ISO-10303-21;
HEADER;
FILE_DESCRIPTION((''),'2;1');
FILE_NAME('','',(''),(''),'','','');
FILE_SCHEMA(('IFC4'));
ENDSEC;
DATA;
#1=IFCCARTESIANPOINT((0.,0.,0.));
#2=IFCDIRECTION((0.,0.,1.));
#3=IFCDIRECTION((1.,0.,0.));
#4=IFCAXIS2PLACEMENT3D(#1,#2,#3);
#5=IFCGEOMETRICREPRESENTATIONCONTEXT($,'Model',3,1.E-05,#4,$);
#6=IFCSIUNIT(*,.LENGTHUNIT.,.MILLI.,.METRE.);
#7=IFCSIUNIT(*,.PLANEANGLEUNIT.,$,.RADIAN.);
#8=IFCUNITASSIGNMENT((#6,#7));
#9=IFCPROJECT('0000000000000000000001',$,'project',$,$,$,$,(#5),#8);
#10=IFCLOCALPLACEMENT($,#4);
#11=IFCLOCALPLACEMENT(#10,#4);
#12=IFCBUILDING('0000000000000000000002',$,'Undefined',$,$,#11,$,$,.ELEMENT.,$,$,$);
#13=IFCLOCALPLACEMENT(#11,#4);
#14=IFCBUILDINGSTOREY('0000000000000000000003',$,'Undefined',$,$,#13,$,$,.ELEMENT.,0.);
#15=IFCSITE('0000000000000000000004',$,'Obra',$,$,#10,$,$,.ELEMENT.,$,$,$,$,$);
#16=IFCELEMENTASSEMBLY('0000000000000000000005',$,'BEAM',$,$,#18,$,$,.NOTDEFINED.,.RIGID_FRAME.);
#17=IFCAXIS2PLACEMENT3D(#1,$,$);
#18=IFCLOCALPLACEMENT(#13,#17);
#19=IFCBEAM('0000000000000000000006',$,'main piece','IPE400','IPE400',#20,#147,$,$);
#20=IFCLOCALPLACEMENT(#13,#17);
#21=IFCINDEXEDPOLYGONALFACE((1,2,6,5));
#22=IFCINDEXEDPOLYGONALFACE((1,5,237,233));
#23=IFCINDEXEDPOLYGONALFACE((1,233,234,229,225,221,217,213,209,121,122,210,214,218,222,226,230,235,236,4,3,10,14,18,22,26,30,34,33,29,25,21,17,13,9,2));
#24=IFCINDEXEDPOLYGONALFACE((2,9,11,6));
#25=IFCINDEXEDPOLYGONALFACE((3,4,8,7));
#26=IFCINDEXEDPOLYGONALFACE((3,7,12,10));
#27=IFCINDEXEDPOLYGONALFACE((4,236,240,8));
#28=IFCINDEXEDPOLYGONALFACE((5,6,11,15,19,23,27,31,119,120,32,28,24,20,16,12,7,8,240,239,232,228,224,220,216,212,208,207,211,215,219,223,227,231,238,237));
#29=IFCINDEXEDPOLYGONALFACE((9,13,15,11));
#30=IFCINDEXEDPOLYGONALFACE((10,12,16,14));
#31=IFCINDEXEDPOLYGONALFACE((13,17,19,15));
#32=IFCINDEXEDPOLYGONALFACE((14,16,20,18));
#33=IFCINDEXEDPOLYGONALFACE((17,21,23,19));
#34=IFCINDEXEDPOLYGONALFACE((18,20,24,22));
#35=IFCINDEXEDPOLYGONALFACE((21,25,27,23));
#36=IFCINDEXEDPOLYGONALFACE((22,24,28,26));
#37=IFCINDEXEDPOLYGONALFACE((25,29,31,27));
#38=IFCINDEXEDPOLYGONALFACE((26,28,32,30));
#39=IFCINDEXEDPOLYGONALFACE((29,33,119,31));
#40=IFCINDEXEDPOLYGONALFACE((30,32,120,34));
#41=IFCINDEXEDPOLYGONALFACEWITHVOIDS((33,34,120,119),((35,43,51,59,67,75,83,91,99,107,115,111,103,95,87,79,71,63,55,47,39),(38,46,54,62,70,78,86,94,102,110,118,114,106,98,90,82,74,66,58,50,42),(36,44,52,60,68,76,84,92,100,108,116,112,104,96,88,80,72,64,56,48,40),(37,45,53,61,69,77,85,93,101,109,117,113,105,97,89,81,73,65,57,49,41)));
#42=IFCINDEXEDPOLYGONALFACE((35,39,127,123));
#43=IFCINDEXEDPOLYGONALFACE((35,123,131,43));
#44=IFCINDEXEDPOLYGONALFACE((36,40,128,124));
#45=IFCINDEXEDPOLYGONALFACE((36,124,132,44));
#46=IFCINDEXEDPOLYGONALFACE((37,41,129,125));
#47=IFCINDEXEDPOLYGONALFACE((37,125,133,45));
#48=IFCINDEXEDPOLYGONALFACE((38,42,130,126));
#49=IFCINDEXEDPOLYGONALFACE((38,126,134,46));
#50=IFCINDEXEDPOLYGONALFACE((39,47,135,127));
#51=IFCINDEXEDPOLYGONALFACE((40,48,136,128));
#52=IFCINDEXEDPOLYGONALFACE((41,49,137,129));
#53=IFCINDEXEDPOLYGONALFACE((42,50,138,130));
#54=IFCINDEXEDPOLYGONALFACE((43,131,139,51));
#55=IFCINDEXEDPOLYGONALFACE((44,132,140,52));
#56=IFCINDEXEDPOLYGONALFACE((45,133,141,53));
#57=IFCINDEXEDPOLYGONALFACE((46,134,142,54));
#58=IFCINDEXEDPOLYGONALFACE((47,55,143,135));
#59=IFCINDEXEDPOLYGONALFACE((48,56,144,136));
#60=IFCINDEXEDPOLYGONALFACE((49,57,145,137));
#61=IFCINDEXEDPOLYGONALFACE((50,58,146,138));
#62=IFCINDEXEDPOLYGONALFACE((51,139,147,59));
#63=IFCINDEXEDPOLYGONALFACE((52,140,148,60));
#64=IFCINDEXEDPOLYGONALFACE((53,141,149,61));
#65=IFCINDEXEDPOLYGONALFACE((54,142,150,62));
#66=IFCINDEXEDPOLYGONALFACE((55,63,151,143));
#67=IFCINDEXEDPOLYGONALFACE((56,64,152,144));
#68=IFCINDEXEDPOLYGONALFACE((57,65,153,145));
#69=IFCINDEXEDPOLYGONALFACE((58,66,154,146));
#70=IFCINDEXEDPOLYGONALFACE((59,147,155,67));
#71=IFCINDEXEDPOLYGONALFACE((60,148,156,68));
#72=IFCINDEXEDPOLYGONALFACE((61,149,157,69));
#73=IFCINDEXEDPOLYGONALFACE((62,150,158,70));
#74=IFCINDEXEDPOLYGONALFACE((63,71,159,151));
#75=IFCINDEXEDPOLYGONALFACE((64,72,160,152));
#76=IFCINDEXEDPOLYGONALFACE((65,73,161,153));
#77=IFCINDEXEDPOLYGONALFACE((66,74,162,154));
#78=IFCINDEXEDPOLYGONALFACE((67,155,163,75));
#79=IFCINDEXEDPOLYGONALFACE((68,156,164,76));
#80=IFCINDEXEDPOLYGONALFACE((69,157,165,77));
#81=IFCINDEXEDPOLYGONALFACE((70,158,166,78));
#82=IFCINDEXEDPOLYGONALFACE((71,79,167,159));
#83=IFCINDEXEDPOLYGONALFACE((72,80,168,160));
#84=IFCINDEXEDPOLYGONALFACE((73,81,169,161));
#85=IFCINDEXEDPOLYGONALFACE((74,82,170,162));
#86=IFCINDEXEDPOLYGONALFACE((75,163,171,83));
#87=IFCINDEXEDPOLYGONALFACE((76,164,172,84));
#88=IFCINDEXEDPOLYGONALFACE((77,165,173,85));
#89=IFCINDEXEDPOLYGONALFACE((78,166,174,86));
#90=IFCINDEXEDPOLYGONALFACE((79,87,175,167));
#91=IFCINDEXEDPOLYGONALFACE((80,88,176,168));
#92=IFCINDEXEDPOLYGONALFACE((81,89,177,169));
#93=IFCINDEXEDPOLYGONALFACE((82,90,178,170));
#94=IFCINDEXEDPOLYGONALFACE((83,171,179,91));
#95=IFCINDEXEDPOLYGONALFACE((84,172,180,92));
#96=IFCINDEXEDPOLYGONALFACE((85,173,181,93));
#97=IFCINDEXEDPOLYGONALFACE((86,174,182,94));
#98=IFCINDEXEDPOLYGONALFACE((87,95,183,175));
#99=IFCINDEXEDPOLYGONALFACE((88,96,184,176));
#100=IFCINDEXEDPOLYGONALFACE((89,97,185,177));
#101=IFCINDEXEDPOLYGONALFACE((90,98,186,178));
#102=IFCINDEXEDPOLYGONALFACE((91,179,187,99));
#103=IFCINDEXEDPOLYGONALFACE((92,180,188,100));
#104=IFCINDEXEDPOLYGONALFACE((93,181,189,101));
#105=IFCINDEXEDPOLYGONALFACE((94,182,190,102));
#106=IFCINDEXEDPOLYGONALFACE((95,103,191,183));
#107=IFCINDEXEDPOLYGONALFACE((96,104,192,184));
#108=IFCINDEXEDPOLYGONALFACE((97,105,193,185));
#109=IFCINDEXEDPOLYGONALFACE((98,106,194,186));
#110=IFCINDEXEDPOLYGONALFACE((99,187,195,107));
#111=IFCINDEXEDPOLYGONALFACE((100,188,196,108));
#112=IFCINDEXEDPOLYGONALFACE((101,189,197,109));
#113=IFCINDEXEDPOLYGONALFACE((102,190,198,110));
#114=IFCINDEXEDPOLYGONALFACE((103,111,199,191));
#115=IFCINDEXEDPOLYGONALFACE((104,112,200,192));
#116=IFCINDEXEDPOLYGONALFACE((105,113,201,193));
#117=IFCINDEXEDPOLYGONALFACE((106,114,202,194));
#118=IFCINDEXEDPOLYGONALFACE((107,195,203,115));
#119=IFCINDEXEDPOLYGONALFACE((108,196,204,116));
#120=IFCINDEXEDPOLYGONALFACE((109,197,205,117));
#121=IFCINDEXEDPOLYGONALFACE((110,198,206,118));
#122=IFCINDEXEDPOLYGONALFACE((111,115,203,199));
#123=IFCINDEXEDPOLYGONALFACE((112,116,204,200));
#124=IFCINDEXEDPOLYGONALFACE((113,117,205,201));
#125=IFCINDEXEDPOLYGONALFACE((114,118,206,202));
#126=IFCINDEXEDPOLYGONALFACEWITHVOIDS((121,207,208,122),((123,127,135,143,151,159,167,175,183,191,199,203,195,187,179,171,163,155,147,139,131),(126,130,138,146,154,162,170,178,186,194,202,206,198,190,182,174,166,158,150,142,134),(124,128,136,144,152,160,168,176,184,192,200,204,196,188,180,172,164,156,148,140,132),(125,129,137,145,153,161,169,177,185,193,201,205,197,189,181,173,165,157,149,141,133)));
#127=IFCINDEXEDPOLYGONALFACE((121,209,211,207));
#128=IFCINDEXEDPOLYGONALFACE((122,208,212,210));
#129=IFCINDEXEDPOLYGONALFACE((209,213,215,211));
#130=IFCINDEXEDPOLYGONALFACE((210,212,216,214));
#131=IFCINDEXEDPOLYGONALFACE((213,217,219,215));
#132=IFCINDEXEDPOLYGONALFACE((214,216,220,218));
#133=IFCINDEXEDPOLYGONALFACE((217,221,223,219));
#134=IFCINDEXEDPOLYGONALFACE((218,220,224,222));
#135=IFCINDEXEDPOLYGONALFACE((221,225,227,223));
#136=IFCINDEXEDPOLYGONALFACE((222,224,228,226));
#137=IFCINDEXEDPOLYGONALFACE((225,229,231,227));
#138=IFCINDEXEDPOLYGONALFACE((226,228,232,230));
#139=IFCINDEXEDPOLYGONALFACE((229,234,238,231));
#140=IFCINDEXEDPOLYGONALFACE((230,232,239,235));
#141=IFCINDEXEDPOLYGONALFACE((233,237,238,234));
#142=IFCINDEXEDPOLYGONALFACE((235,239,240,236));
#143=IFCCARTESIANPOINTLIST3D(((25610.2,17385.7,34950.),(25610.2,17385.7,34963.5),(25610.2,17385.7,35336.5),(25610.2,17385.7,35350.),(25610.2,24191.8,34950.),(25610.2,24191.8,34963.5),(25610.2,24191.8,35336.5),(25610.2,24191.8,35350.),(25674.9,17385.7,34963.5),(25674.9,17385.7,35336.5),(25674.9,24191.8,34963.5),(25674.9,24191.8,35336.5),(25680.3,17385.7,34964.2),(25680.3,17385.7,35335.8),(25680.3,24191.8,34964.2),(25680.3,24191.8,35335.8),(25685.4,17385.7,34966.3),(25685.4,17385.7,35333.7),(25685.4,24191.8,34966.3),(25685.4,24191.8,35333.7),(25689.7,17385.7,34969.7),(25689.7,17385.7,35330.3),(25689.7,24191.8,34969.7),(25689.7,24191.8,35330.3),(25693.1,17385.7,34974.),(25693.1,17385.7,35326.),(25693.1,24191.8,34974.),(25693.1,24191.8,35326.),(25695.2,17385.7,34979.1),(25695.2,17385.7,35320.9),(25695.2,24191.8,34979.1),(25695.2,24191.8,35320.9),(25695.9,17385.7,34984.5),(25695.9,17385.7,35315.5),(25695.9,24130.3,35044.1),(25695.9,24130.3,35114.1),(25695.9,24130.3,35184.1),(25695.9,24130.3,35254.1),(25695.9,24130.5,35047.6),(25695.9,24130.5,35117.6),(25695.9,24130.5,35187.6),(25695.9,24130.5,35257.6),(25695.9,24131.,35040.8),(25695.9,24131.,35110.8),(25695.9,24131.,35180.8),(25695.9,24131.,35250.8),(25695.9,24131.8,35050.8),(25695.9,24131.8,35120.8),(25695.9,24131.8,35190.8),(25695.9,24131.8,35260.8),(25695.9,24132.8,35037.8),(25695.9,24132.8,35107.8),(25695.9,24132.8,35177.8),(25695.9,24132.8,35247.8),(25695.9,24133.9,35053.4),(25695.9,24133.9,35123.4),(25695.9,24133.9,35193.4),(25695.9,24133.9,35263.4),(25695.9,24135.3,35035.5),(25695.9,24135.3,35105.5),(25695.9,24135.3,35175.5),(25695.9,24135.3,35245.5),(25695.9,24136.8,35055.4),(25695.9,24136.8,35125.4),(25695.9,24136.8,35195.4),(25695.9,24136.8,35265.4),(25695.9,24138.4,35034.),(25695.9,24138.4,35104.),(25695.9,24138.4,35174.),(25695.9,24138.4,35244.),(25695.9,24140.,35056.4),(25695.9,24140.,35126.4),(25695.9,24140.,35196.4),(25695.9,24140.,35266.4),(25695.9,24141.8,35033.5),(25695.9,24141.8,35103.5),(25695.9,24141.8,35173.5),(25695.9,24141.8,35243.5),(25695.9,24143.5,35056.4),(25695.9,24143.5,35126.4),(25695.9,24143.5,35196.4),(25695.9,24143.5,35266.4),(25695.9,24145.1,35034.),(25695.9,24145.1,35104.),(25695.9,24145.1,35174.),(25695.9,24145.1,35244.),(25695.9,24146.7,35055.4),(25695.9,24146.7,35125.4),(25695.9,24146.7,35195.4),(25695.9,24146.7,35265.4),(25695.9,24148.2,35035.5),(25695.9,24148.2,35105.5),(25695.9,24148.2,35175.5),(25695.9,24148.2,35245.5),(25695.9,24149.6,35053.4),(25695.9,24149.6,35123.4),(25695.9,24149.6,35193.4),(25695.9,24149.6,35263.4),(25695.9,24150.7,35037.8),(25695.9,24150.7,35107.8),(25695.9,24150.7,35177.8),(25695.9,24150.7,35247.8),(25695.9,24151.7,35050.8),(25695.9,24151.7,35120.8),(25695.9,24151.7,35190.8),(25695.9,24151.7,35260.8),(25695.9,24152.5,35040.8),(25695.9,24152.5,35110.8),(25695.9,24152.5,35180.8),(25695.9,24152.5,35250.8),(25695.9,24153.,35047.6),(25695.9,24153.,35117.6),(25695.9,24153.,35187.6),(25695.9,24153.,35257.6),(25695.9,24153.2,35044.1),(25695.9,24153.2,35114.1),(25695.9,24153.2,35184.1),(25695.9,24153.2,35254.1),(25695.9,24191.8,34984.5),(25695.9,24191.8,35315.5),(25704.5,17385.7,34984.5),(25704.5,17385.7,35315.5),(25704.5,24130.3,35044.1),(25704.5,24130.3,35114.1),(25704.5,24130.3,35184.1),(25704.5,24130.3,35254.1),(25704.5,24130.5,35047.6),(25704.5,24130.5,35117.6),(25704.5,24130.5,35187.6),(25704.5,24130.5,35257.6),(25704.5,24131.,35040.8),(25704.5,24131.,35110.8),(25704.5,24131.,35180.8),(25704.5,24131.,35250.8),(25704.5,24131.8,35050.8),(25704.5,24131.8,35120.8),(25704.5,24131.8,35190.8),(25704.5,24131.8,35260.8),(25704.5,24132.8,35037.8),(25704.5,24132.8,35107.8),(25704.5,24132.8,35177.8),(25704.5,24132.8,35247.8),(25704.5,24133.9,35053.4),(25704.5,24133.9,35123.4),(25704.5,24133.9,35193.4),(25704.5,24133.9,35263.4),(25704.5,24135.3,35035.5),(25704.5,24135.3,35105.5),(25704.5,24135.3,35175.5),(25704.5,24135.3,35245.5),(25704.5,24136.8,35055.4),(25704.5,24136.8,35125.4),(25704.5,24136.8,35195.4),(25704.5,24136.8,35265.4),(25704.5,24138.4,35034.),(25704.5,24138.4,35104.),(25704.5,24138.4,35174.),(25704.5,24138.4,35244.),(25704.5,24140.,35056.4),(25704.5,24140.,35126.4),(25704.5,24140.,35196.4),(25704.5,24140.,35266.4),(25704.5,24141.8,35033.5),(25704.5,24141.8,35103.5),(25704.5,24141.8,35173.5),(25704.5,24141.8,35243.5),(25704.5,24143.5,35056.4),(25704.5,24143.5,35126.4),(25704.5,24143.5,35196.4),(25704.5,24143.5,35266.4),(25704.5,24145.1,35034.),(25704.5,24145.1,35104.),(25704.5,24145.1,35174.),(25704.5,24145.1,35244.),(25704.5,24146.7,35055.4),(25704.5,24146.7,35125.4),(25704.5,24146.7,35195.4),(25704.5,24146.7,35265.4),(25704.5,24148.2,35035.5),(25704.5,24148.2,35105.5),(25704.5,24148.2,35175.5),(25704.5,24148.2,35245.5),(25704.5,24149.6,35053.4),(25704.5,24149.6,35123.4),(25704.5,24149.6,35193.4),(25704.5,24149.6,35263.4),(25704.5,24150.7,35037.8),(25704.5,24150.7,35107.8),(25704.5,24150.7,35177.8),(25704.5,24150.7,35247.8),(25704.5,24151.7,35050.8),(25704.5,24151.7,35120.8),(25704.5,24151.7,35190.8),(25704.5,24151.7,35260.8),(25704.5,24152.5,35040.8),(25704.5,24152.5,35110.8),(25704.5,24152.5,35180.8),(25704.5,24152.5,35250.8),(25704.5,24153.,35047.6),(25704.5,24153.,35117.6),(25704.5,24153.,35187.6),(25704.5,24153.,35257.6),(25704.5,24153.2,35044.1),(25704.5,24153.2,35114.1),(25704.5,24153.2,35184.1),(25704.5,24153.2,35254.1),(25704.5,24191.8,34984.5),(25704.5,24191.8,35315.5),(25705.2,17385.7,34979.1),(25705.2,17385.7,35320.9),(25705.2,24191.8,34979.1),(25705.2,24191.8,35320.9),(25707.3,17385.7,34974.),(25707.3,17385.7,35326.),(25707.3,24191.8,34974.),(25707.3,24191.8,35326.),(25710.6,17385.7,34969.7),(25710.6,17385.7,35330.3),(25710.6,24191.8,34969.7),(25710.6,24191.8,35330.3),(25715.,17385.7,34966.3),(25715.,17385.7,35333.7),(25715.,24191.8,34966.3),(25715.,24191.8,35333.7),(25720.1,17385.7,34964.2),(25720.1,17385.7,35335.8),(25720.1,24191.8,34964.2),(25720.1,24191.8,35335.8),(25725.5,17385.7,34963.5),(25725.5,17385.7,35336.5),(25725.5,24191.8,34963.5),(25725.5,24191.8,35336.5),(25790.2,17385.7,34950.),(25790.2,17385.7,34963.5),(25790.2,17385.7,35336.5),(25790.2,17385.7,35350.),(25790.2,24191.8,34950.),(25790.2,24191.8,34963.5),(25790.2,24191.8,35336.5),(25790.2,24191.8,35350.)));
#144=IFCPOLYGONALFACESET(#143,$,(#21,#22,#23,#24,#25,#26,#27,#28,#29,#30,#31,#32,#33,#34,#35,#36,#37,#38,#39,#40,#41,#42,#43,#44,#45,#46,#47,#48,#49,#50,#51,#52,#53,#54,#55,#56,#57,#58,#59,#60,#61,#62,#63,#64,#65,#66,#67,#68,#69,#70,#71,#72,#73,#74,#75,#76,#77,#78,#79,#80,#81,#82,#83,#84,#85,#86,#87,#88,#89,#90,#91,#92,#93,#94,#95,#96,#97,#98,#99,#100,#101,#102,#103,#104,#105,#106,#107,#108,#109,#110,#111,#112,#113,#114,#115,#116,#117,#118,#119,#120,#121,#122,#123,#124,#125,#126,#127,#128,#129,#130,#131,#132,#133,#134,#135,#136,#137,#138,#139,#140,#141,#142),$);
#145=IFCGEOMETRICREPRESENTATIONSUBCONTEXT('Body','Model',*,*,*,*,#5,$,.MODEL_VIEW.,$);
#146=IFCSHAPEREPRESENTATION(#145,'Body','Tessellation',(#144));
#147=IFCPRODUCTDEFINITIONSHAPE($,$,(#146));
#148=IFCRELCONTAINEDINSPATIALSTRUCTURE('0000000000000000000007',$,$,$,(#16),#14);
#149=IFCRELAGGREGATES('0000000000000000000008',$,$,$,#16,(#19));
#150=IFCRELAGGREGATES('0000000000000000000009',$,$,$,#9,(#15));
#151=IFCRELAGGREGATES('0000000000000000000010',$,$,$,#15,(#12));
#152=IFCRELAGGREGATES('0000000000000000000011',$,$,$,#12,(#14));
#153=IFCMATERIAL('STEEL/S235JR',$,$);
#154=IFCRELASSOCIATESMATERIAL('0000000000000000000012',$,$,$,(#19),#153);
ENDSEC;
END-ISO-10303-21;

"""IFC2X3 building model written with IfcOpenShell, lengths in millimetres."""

from ifc_helpers import new_model, si_unit, frame, origin_with_axes, origin_2d_with_axis, place, context, subcontext, project, spatial, circle, i_section, extrude, clip, halfspace, source, transform, mapped, material, element, aggregate, save


model = new_model("IFC2X3")

# Units and contexts
model_context = context("Model", 3, precision=1e-05, world=origin_with_axes())
body_context = subcontext(model_context, "Body", "Model", "MODEL_VIEW")
ifc_project = project(units=[si_unit("LENGTHUNIT", "METRE", prefix="MILLI"), si_unit("PLANEANGLEUNIT", "RADIAN")], contexts=[model_context])

# Site, building, storey
site_placement = place(None, origin_with_axes())
site = spatial("IfcSite", under=ifc_project, at=site_placement, Name="Obra", CompositionType="ELEMENT")
building_placement = place(site_placement, origin_with_axes())
building = spatial("IfcBuilding", under=site, at=building_placement, Name="Undefined", CompositionType="ELEMENT")
storey_placement = place(building_placement, origin_with_axes())
storey = spatial("IfcBuildingStorey", under=building, at=storey_placement, Name="Undefined", CompositionType="ELEMENT", Elevation=0.0)

# Element assembly, beam, opening
assembly_1_placement = place(storey_placement, origin_with_axes())
assembly_1 = element("IfcElementAssembly", 1, at=assembly_1_placement, inside=storey, Name="BEAM", AssemblyPlace="NOTDEFINED", PredefinedType="RIGID_FRAME")
ifc_material_1 = material(Name="STEEL/S235JR")
beam_placement = place(assembly_1_placement, frame((25700.2, 24354.3, 35150.0), z_axis=(0.0, 0.0, 1.0), x_axis=(0.0, -1.0, 0.0)))
beam = element("IfcBeam", 2, at=beam_placement, material=ifc_material_1, Name="main piece", Description="IPE400", ObjectType="IPE400", context=body_context, shape_type="Clipping", body=[
    clip(extrude(i_section(OverallWidth=180.0, OverallDepth=400.0, WebThickness=8.6, FlangeThickness=13.5, FilletRadius=21.0, at=origin_2d_with_axis()), frame((6968.6, 0.0, 0.0), z_axis=(-1.0, 0.0, 0.0), x_axis=(0.0, -1.0, 0.0)), (0.0, 0.0, 1.0), 6806.1), halfspace(frame((162.5, 0.0, -300.0), z_axis=(1.0, 0.0, 0.0), x_axis=(0.0, -1.0, 0.0)), True)),
])
shared_shape_1 = source(origin_with_axes(), body_context, "Body", "SweptSolid", [
    extrude(circle(Radius=11.5, at=origin_2d_with_axis()), frame((0.0, -4.4, 0.0), z_axis=(0.0, 1.0, 0.0), x_axis=(1.0, 0.0, 0.0)), (0.0, 0.0, 1.0), 8.8),
])
opening_1_placement = place(assembly_1_placement, frame((25700.2, 24191.8, 35350.0), z_axis=(0.0, -1.0, 0.0), x_axis=(0.0, 0.0, -1.0)))
element("IfcOpeningElement", 3, at=opening_1_placement, cuts=beam, ObjectType="Opening", context=body_context, shape_type="MappedRepresentation", body=[
    mapped(shared_shape_1, transform((95.0, 0.0, 50.0))),
    mapped(shared_shape_1, transform((165.0, 0.0, 50.0))),
    mapped(shared_shape_1, transform((235.0, 0.0, 50.0))),
    mapped(shared_shape_1, transform((305.0, 0.0, 50.0))),
])

aggregate(assembly_1, [beam])

save(model, "model.ifc")
